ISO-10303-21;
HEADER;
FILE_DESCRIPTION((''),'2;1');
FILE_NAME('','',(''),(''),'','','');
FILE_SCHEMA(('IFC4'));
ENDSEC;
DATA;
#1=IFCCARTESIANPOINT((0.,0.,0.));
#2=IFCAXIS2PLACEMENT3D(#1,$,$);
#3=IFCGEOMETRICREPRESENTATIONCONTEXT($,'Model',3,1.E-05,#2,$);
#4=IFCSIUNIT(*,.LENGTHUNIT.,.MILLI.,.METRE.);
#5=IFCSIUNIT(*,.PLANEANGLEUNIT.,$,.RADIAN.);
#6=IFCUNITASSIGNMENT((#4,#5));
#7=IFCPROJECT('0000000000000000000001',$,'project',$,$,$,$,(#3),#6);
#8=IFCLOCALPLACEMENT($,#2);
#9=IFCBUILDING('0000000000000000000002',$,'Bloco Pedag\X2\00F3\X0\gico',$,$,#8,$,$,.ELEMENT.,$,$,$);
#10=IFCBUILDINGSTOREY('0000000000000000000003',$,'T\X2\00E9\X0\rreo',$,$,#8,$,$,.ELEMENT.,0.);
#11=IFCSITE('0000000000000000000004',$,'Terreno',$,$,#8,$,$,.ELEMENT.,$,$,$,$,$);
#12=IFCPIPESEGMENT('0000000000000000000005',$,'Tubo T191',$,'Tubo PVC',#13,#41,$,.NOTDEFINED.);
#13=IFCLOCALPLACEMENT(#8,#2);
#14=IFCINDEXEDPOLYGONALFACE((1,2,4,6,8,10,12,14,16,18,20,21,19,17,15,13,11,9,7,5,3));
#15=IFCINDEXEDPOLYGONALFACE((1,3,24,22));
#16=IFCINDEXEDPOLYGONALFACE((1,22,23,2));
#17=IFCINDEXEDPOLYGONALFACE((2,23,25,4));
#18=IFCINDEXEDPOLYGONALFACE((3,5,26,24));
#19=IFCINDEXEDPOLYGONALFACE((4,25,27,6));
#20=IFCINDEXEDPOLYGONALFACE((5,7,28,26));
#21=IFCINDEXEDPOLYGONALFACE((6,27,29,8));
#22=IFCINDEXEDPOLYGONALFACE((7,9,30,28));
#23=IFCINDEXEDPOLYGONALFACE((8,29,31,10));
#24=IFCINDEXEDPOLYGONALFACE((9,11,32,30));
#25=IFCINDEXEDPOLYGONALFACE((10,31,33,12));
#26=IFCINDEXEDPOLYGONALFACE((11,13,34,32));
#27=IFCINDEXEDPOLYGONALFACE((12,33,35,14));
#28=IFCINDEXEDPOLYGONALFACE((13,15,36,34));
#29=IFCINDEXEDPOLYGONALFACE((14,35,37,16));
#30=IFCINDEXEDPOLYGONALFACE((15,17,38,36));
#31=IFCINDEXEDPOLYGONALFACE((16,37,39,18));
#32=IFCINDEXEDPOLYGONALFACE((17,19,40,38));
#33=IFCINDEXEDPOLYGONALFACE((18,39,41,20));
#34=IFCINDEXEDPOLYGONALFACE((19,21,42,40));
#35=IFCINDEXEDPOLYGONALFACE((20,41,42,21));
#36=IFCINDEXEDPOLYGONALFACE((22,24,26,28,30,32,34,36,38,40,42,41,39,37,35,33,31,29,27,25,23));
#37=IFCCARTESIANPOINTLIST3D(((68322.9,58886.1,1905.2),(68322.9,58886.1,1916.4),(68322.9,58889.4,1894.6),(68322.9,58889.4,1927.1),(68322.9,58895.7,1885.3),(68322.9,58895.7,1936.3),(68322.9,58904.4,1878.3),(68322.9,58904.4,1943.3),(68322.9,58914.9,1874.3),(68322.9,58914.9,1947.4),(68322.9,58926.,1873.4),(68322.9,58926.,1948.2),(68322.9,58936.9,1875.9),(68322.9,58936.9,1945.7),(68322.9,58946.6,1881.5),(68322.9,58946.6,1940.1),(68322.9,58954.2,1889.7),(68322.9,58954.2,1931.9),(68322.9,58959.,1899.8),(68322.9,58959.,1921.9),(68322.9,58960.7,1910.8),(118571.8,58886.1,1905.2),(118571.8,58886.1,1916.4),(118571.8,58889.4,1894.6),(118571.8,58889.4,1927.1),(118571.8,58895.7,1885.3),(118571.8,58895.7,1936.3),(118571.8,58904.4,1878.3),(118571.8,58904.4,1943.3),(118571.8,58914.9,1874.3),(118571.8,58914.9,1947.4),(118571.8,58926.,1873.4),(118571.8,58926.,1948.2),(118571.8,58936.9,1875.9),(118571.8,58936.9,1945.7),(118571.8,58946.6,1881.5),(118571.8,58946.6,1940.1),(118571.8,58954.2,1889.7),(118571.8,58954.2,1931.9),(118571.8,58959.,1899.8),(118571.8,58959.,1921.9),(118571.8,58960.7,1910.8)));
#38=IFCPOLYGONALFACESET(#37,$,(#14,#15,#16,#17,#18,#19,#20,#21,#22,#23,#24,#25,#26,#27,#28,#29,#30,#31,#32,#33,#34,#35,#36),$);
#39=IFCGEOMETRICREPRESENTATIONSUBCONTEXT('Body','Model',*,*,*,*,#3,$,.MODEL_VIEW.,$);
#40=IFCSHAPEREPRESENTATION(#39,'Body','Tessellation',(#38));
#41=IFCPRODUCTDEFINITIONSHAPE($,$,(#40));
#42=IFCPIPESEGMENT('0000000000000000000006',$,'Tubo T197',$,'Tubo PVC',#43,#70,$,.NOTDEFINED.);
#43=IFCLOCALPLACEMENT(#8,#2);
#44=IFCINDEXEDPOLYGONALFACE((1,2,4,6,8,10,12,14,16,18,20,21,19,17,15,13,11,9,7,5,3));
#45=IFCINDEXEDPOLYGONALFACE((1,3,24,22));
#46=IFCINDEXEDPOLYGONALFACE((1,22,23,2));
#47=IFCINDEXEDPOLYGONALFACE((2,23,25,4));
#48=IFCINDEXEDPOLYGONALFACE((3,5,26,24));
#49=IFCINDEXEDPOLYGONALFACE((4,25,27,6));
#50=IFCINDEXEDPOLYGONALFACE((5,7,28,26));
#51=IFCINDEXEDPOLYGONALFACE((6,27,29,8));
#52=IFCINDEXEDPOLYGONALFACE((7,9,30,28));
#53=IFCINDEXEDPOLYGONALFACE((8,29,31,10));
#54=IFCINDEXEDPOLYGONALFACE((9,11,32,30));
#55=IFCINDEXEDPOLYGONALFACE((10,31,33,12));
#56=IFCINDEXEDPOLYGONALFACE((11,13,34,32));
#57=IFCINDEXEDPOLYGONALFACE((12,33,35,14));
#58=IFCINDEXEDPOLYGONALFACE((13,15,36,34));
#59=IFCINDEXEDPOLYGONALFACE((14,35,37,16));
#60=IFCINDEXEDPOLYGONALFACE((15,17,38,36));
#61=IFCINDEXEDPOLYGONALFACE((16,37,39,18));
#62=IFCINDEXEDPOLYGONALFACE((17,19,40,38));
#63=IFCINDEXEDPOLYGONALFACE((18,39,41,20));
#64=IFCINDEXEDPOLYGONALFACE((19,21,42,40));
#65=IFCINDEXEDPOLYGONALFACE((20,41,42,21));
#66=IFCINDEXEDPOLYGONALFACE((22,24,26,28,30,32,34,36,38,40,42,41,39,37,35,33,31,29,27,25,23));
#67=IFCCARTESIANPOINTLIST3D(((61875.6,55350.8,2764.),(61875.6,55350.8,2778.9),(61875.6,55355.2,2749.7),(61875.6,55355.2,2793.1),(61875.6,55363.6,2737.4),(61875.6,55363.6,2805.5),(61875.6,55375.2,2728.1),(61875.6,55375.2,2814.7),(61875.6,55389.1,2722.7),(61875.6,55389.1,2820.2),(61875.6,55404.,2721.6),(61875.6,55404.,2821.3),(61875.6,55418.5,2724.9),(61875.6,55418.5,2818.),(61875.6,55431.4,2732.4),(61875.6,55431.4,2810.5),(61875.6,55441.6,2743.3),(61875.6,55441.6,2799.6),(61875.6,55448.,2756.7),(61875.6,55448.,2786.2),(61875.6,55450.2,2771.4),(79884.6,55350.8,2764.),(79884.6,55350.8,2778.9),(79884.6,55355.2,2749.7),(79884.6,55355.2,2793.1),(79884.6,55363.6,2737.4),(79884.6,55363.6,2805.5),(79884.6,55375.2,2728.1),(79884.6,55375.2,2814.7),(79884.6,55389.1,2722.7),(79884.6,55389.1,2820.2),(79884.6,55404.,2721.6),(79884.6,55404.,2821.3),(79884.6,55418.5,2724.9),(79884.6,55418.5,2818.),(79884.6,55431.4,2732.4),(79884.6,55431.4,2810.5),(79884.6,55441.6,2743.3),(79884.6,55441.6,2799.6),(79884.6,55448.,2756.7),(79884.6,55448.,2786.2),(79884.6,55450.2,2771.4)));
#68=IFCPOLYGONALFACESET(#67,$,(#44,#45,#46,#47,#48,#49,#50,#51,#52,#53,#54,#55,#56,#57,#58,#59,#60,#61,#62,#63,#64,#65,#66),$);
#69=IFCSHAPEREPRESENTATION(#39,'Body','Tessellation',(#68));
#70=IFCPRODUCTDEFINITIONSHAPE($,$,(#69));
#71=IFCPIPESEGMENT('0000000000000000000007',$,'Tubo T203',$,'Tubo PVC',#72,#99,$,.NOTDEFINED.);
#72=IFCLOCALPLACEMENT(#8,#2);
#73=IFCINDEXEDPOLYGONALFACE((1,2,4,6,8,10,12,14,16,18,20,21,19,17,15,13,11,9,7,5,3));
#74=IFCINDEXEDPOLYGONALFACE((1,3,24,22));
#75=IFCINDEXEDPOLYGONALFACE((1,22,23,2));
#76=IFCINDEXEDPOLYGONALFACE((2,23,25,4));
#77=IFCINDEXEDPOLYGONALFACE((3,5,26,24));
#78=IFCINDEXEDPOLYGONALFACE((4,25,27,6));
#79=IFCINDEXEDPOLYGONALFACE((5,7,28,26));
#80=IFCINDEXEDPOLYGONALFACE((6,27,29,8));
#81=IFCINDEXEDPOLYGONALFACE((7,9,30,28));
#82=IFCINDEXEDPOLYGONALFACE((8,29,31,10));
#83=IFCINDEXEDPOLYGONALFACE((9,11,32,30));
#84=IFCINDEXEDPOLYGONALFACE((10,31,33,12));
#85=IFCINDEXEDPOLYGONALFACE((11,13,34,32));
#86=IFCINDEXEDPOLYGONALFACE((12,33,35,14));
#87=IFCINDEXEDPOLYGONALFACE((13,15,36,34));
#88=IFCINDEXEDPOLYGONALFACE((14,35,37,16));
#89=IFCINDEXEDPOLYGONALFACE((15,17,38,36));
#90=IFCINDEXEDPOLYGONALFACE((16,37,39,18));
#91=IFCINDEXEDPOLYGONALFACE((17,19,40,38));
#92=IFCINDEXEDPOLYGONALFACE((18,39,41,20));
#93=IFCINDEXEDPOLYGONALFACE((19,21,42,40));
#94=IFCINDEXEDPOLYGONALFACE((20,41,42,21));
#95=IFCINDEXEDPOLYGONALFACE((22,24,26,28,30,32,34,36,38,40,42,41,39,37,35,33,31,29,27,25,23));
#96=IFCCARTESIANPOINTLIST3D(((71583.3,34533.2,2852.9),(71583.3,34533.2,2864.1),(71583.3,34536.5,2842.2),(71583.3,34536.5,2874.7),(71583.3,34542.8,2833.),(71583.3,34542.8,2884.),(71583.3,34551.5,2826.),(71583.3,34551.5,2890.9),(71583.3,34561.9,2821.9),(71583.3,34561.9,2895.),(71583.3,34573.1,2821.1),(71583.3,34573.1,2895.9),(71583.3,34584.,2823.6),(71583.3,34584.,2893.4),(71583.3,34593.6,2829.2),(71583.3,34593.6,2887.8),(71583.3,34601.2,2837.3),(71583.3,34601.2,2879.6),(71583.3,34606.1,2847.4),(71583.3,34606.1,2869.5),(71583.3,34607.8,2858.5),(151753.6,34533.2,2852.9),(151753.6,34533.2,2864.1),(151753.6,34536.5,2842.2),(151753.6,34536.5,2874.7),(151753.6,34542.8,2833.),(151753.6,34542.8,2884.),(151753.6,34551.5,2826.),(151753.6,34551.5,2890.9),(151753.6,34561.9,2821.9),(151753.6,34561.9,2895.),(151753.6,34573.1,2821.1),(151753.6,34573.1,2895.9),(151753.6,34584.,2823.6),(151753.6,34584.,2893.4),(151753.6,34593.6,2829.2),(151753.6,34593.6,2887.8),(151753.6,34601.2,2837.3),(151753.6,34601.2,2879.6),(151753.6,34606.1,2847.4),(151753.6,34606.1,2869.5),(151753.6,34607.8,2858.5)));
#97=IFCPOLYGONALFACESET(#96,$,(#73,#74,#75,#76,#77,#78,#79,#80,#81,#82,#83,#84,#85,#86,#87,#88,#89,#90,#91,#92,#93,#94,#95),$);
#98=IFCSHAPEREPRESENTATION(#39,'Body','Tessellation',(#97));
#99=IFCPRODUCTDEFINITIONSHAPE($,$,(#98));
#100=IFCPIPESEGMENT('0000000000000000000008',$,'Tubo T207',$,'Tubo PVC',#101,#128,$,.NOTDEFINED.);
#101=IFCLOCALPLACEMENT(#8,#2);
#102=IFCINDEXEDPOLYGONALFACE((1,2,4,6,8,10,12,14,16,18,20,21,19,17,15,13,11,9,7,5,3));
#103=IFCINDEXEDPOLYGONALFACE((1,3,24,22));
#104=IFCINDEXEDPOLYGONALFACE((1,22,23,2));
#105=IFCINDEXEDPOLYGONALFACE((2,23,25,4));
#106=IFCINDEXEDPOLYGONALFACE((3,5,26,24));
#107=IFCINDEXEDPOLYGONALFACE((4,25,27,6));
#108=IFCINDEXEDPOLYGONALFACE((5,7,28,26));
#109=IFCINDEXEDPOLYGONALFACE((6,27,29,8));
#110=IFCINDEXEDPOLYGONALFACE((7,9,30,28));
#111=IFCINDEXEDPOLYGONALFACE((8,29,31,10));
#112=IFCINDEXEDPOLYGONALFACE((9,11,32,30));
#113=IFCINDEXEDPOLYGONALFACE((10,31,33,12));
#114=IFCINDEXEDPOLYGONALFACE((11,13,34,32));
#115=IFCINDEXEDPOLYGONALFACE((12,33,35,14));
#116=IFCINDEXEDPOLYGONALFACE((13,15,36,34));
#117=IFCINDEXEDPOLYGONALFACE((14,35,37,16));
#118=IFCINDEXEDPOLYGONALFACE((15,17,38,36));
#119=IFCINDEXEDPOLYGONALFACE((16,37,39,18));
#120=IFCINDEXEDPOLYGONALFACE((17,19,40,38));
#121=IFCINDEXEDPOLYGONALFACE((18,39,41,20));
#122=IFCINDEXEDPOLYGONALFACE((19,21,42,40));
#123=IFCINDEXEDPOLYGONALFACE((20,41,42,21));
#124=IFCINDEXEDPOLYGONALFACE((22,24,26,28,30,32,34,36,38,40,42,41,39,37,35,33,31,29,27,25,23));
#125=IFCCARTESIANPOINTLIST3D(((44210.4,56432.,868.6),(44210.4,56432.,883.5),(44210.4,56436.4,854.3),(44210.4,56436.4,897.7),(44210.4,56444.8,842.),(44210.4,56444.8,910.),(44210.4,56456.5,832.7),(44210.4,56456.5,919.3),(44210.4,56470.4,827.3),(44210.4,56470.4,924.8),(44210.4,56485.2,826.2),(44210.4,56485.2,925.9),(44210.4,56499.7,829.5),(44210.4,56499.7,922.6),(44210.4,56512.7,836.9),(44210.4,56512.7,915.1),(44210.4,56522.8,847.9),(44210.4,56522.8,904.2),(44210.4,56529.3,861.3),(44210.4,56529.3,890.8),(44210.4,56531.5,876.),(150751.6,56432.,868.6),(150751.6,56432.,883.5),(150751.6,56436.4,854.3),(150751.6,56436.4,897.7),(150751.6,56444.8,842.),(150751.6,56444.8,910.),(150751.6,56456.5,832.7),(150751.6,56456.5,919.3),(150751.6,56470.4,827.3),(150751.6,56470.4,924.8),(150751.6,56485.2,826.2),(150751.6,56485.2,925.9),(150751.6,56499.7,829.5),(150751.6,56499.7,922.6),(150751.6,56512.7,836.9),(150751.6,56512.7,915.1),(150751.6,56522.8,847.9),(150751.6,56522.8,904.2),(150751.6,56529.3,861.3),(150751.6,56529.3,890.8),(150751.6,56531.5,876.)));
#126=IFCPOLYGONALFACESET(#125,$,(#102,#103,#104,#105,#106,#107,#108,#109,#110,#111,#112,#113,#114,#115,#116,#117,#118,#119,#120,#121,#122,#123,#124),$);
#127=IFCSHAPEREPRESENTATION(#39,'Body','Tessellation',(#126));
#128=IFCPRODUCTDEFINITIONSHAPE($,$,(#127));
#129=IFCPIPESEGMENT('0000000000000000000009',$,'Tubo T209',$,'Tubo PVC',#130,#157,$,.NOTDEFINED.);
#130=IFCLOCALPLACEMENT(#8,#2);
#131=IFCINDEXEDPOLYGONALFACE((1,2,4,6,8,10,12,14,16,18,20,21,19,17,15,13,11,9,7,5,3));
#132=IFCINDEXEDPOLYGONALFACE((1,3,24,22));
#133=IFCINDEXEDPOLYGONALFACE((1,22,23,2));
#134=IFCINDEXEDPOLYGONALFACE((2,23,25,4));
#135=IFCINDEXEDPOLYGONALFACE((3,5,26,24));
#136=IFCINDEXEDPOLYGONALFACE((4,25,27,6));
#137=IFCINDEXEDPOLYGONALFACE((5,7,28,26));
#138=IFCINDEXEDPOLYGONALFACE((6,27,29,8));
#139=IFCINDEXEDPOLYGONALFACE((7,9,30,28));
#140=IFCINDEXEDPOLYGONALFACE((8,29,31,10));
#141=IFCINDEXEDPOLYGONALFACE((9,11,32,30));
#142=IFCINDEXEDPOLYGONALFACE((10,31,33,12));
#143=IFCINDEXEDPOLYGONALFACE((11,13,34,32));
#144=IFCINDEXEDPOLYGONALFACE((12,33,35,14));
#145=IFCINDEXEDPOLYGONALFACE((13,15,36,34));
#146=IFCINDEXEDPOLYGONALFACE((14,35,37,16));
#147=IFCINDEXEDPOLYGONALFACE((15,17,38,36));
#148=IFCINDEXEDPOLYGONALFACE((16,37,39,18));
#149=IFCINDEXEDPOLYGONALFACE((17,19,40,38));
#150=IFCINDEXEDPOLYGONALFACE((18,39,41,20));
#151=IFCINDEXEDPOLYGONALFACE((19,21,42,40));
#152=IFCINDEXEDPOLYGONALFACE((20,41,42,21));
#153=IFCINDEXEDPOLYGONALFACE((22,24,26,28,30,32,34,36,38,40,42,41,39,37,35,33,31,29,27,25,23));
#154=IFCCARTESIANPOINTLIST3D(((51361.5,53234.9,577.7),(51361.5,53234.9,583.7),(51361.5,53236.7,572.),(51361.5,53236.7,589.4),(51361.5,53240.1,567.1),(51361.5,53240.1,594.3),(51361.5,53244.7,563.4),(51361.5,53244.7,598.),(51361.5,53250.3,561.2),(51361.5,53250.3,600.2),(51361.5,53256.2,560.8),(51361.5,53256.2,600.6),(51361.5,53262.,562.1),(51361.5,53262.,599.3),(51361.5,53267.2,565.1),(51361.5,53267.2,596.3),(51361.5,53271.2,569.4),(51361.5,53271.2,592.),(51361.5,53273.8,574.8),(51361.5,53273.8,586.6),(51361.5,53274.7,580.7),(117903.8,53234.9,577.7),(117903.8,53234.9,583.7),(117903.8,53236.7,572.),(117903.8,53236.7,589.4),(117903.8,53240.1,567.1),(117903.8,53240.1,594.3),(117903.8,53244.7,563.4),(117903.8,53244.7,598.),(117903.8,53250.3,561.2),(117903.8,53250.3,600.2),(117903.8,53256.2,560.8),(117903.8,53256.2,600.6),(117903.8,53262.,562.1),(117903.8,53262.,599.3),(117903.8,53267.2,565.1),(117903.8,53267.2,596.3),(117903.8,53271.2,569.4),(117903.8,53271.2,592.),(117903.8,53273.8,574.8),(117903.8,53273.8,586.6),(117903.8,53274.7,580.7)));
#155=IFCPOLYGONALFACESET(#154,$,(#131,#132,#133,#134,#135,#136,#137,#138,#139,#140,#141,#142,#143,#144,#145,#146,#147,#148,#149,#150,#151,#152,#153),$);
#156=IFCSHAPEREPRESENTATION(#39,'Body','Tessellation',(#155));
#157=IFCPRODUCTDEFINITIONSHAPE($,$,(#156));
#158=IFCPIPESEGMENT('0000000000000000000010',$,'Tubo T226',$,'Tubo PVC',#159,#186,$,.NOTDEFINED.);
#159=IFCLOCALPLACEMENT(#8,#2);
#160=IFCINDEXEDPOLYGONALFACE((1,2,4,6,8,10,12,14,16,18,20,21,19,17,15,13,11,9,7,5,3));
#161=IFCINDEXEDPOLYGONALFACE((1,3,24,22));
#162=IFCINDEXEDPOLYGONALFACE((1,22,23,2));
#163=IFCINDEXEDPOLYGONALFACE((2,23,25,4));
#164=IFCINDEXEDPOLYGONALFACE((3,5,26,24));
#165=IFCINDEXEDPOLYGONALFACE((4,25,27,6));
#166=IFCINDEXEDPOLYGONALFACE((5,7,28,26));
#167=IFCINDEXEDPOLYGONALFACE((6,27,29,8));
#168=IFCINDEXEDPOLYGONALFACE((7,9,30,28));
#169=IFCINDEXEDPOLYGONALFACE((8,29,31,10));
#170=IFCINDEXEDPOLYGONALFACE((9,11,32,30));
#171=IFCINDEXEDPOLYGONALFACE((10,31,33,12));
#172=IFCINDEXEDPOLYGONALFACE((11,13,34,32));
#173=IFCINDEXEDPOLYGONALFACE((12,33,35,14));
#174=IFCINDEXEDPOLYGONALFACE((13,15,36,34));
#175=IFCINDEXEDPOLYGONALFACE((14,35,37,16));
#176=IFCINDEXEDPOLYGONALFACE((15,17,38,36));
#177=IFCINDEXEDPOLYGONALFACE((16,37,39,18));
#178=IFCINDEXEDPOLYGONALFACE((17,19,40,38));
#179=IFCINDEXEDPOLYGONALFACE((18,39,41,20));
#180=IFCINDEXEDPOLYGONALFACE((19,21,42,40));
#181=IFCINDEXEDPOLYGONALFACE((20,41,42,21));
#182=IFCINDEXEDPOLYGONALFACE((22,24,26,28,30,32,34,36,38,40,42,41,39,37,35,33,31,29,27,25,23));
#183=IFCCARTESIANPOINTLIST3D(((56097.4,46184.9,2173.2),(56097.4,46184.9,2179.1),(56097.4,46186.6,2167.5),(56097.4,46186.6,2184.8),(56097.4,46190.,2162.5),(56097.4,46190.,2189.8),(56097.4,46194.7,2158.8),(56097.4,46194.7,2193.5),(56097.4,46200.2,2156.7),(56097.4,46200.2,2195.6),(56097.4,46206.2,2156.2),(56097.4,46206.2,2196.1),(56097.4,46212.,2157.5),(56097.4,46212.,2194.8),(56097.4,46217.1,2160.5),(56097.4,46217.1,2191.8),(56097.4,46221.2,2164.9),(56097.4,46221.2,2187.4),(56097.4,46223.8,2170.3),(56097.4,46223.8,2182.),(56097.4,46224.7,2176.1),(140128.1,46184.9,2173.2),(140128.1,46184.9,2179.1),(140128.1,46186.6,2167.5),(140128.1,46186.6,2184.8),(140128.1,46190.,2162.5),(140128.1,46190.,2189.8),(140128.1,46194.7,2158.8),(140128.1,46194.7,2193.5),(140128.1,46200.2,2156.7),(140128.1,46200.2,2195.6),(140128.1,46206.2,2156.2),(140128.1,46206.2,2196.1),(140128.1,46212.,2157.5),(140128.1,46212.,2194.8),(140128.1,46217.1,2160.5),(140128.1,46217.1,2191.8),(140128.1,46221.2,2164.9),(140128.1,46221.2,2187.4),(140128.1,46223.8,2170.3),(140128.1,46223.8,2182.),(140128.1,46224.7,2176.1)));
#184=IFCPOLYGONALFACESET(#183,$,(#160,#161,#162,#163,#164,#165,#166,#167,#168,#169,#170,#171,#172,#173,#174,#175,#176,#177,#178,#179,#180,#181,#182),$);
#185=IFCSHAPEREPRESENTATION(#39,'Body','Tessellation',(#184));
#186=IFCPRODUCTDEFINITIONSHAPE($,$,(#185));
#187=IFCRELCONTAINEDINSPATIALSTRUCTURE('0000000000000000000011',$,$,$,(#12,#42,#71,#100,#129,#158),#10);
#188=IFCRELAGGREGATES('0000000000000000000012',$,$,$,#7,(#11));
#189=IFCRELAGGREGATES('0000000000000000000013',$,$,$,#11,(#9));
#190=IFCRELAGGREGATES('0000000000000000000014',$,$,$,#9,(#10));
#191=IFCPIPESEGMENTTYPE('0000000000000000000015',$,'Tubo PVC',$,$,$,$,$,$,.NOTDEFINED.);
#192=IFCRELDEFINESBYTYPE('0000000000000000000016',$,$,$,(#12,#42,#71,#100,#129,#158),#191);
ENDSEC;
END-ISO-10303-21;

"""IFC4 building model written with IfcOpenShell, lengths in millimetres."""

from ifc_helpers import new_model, si_unit, frame, origin, origin_2d, place, context, subcontext, project, spatial, circle, extrude, type_object, element, save


model = new_model("IFC4")

# Units and contexts
model_context = context("Model", 3, precision=1e-05, world=origin())
body_context = subcontext(model_context, "Body", "Model", "MODEL_VIEW")
ifc_project = project(units=[si_unit("LENGTHUNIT", "METRE", prefix="MILLI"), si_unit("PLANEANGLEUNIT", "RADIAN")], contexts=[model_context])

# Site, building, storey
placement = place(None, origin())
site = spatial("IfcSite", under=ifc_project, at=placement, Name="Terreno", CompositionType="ELEMENT")
building = spatial("IfcBuilding", under=site, at=placement, Name="Bloco Pedagógico", CompositionType="ELEMENT")
storey = spatial("IfcBuildingStorey", under=building, at=placement, Name="Térreo", CompositionType="ELEMENT", Elevation=0.0)

# Pipe segments
pipe_segment_type = type_object("IfcPipeSegmentType", Name="Tubo PVC", PredefinedType="NOTDEFINED")
pipe_segment_1_placement = place(None, frame((68322.9, 58923.2, 1910.8), z_axis=(1.0, 0.0, 0.0), x_axis=(0.0, 1.0, 0.0)))
element("IfcPipeSegment", 1, at=pipe_segment_1_placement, inside=storey, type_object=pipe_segment_type, Name="Tubo T191", ObjectType="Tubo PVC", PredefinedType="NOTDEFINED", context=body_context, shape_type="SweptSolid", body=[
    extrude(circle(Radius=37.5, at=origin_2d()), None, (0.0, 0.0, 1.0), 50248.9),
])
pipe_segment_2_placement = place(None, frame((61875.6, 55400.2, 2771.4), z_axis=(1.0, 0.0, 0.0), x_axis=(0.0, 1.0, 0.0)))
element("IfcPipeSegment", 2, at=pipe_segment_2_placement, inside=storey, type_object=pipe_segment_type, Name="Tubo T197", ObjectType="Tubo PVC", PredefinedType="NOTDEFINED", context=body_context, shape_type="SweptSolid", body=[
    extrude(circle(Radius=50.0, at=origin_2d()), None, (0.0, 0.0, 1.0), 18009.0),
])
pipe_segment_3_placement = place(None, frame((71583.3, 34570.3, 2858.5), z_axis=(1.0, 0.0, 0.0), x_axis=(0.0, 1.0, 0.0)))
element("IfcPipeSegment", 3, at=pipe_segment_3_placement, inside=storey, type_object=pipe_segment_type, Name="Tubo T203", ObjectType="Tubo PVC", PredefinedType="NOTDEFINED", context=body_context, shape_type="SweptSolid", body=[
    extrude(circle(Radius=37.5, at=origin_2d()), None, (0.0, 0.0, 1.0), 80170.4),
])
pipe_segment_4_placement = place(None, frame((44210.4, 56481.5, 876.0), z_axis=(1.0, 0.0, 0.0), x_axis=(0.0, 1.0, 0.0)))
element("IfcPipeSegment", 4, at=pipe_segment_4_placement, inside=storey, type_object=pipe_segment_type, Name="Tubo T207", ObjectType="Tubo PVC", PredefinedType="NOTDEFINED", context=body_context, shape_type="SweptSolid", body=[
    extrude(circle(Radius=50.0, at=origin_2d()), None, (0.0, 0.0, 1.0), 106541.3),
])
pipe_segment_5_placement = place(None, frame((51361.5, 53254.7, 580.7), z_axis=(1.0, 0.0, 0.0), x_axis=(0.0, 1.0, 0.0)))
element("IfcPipeSegment", 5, at=pipe_segment_5_placement, inside=storey, type_object=pipe_segment_type, Name="Tubo T209", ObjectType="Tubo PVC", PredefinedType="NOTDEFINED", context=body_context, shape_type="SweptSolid", body=[
    extrude(circle(Radius=20.0, at=origin_2d()), None, (0.0, 0.0, 1.0), 66542.3),
])
pipe_segment_6_placement = place(None, frame((56097.4, 46204.7, 2176.1), z_axis=(1.0, 0.0, 0.0), x_axis=(0.0, 1.0, 0.0)))
element("IfcPipeSegment", 6, at=pipe_segment_6_placement, inside=storey, type_object=pipe_segment_type, Name="Tubo T226", ObjectType="Tubo PVC", PredefinedType="NOTDEFINED", context=body_context, shape_type="SweptSolid", body=[
    extrude(circle(Radius=20.0, at=origin_2d()), None, (0.0, 0.0, 1.0), 84030.7),
])

save(model, "model.ifc")
